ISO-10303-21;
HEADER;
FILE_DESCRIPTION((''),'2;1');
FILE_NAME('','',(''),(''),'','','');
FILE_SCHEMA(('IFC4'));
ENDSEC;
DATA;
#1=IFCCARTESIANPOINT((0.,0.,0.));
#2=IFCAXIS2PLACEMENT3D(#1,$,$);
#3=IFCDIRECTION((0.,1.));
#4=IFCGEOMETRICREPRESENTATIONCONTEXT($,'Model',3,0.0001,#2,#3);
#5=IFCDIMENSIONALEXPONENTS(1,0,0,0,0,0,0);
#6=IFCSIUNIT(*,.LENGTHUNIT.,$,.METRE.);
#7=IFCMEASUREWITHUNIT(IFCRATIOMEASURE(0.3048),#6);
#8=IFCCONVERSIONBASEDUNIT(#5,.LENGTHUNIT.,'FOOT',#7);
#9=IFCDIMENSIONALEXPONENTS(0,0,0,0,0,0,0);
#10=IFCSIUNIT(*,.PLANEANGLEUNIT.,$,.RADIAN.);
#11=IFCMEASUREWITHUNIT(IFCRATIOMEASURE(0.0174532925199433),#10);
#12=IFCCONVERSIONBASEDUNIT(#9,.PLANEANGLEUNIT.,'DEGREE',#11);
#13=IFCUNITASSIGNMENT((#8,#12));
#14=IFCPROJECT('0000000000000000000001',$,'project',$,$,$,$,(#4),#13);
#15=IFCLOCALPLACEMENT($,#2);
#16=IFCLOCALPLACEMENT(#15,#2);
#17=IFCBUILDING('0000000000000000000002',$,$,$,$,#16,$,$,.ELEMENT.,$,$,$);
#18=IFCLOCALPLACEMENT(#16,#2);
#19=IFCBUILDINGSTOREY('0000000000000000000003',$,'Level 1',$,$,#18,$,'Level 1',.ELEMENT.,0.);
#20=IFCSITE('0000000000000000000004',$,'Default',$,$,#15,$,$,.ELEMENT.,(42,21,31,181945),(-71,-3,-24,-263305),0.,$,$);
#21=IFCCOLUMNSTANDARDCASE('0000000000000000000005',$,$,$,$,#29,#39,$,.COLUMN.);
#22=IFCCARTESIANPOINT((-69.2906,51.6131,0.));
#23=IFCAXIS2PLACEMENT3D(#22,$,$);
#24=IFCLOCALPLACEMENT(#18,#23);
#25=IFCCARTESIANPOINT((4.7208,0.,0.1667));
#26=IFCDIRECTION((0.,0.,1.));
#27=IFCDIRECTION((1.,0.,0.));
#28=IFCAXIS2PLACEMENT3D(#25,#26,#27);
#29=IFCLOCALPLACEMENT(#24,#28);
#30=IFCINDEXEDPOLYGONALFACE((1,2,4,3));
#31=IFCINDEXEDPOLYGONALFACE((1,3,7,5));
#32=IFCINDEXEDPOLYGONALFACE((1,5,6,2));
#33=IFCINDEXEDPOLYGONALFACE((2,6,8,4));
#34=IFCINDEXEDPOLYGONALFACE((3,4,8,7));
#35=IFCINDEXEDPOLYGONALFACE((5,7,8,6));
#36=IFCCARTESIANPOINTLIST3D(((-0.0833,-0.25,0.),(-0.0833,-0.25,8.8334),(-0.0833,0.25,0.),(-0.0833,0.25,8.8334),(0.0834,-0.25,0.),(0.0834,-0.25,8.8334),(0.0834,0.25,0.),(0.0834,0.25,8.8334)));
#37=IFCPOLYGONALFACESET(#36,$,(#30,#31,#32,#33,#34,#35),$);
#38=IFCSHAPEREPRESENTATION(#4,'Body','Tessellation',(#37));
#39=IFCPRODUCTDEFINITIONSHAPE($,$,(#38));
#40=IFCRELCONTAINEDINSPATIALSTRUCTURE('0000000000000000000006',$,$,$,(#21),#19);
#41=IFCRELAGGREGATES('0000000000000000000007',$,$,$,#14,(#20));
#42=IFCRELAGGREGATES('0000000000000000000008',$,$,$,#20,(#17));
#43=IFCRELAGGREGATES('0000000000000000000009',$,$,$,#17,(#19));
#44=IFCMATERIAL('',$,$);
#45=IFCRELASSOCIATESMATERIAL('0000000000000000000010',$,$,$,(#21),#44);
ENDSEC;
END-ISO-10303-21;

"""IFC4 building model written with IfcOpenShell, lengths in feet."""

from ifc_helpers import new_model, entity, si_unit, converted_unit, direction, frame, origin, place, context, project, spatial, rectangle, extrude, material, element, save


model = new_model("IFC4")

# Units and contexts
model_context = context("Model", 3, precision=0.0001, world=origin(), true_north=direction((0.0, 1.0)))
ifc_project = project(units=[converted_unit("LENGTHUNIT", "FOOT", entity("IfcRatioMeasure", 0.3048), si_unit("LENGTHUNIT", "METRE"), dimensions=[1, 0, 0, 0, 0, 0, 0]), converted_unit("PLANEANGLEUNIT", "DEGREE", entity("IfcRatioMeasure", 0.0174532925199433), si_unit("PLANEANGLEUNIT", "RADIAN"), dimensions=[0, 0, 0, 0, 0, 0, 0])], contexts=[model_context])

# Site, building, storey
site_placement = place(None, origin())
site = spatial("IfcSite", under=ifc_project, at=site_placement, Name="Default", CompositionType="ELEMENT", RefLatitude=(42, 21, 31, 181945), RefLongitude=(-71, -3, -24, -263305), RefElevation=0.0)
building_placement = place(site_placement, origin())
building = spatial("IfcBuilding", under=site, at=building_placement, CompositionType="ELEMENT")
storey_placement = place(building_placement, origin())
storey = spatial("IfcBuildingStorey", under=building, at=storey_placement, Name="Level 1", LongName="Level 1", CompositionType="ELEMENT", Elevation=0.0)

# Column
ifc_material_1 = material(Name="")
placement_1 = place(storey_placement, frame((-69.2906, 51.6131, 0.0)))
for number, where, z_axis, x_axis in (
    (1, (4.7208, 0.0, 0.1667), (0.0, 0.0, 1.0), (1.0, 0.0, 0.0)),
):
    element("IfcColumnStandardCase", number, at=place(placement_1, frame(where, z_axis=z_axis, x_axis=x_axis)), inside=storey, material=ifc_material_1, PredefinedType="COLUMN", context=model_context, shape_type="SweptSolid", body=[
        extrude(rectangle(XDim=0.1667, YDim=0.5), origin(), (0.0, 0.0, 1.0), 8.8334),
    ])

save(model, "model.ifc")
